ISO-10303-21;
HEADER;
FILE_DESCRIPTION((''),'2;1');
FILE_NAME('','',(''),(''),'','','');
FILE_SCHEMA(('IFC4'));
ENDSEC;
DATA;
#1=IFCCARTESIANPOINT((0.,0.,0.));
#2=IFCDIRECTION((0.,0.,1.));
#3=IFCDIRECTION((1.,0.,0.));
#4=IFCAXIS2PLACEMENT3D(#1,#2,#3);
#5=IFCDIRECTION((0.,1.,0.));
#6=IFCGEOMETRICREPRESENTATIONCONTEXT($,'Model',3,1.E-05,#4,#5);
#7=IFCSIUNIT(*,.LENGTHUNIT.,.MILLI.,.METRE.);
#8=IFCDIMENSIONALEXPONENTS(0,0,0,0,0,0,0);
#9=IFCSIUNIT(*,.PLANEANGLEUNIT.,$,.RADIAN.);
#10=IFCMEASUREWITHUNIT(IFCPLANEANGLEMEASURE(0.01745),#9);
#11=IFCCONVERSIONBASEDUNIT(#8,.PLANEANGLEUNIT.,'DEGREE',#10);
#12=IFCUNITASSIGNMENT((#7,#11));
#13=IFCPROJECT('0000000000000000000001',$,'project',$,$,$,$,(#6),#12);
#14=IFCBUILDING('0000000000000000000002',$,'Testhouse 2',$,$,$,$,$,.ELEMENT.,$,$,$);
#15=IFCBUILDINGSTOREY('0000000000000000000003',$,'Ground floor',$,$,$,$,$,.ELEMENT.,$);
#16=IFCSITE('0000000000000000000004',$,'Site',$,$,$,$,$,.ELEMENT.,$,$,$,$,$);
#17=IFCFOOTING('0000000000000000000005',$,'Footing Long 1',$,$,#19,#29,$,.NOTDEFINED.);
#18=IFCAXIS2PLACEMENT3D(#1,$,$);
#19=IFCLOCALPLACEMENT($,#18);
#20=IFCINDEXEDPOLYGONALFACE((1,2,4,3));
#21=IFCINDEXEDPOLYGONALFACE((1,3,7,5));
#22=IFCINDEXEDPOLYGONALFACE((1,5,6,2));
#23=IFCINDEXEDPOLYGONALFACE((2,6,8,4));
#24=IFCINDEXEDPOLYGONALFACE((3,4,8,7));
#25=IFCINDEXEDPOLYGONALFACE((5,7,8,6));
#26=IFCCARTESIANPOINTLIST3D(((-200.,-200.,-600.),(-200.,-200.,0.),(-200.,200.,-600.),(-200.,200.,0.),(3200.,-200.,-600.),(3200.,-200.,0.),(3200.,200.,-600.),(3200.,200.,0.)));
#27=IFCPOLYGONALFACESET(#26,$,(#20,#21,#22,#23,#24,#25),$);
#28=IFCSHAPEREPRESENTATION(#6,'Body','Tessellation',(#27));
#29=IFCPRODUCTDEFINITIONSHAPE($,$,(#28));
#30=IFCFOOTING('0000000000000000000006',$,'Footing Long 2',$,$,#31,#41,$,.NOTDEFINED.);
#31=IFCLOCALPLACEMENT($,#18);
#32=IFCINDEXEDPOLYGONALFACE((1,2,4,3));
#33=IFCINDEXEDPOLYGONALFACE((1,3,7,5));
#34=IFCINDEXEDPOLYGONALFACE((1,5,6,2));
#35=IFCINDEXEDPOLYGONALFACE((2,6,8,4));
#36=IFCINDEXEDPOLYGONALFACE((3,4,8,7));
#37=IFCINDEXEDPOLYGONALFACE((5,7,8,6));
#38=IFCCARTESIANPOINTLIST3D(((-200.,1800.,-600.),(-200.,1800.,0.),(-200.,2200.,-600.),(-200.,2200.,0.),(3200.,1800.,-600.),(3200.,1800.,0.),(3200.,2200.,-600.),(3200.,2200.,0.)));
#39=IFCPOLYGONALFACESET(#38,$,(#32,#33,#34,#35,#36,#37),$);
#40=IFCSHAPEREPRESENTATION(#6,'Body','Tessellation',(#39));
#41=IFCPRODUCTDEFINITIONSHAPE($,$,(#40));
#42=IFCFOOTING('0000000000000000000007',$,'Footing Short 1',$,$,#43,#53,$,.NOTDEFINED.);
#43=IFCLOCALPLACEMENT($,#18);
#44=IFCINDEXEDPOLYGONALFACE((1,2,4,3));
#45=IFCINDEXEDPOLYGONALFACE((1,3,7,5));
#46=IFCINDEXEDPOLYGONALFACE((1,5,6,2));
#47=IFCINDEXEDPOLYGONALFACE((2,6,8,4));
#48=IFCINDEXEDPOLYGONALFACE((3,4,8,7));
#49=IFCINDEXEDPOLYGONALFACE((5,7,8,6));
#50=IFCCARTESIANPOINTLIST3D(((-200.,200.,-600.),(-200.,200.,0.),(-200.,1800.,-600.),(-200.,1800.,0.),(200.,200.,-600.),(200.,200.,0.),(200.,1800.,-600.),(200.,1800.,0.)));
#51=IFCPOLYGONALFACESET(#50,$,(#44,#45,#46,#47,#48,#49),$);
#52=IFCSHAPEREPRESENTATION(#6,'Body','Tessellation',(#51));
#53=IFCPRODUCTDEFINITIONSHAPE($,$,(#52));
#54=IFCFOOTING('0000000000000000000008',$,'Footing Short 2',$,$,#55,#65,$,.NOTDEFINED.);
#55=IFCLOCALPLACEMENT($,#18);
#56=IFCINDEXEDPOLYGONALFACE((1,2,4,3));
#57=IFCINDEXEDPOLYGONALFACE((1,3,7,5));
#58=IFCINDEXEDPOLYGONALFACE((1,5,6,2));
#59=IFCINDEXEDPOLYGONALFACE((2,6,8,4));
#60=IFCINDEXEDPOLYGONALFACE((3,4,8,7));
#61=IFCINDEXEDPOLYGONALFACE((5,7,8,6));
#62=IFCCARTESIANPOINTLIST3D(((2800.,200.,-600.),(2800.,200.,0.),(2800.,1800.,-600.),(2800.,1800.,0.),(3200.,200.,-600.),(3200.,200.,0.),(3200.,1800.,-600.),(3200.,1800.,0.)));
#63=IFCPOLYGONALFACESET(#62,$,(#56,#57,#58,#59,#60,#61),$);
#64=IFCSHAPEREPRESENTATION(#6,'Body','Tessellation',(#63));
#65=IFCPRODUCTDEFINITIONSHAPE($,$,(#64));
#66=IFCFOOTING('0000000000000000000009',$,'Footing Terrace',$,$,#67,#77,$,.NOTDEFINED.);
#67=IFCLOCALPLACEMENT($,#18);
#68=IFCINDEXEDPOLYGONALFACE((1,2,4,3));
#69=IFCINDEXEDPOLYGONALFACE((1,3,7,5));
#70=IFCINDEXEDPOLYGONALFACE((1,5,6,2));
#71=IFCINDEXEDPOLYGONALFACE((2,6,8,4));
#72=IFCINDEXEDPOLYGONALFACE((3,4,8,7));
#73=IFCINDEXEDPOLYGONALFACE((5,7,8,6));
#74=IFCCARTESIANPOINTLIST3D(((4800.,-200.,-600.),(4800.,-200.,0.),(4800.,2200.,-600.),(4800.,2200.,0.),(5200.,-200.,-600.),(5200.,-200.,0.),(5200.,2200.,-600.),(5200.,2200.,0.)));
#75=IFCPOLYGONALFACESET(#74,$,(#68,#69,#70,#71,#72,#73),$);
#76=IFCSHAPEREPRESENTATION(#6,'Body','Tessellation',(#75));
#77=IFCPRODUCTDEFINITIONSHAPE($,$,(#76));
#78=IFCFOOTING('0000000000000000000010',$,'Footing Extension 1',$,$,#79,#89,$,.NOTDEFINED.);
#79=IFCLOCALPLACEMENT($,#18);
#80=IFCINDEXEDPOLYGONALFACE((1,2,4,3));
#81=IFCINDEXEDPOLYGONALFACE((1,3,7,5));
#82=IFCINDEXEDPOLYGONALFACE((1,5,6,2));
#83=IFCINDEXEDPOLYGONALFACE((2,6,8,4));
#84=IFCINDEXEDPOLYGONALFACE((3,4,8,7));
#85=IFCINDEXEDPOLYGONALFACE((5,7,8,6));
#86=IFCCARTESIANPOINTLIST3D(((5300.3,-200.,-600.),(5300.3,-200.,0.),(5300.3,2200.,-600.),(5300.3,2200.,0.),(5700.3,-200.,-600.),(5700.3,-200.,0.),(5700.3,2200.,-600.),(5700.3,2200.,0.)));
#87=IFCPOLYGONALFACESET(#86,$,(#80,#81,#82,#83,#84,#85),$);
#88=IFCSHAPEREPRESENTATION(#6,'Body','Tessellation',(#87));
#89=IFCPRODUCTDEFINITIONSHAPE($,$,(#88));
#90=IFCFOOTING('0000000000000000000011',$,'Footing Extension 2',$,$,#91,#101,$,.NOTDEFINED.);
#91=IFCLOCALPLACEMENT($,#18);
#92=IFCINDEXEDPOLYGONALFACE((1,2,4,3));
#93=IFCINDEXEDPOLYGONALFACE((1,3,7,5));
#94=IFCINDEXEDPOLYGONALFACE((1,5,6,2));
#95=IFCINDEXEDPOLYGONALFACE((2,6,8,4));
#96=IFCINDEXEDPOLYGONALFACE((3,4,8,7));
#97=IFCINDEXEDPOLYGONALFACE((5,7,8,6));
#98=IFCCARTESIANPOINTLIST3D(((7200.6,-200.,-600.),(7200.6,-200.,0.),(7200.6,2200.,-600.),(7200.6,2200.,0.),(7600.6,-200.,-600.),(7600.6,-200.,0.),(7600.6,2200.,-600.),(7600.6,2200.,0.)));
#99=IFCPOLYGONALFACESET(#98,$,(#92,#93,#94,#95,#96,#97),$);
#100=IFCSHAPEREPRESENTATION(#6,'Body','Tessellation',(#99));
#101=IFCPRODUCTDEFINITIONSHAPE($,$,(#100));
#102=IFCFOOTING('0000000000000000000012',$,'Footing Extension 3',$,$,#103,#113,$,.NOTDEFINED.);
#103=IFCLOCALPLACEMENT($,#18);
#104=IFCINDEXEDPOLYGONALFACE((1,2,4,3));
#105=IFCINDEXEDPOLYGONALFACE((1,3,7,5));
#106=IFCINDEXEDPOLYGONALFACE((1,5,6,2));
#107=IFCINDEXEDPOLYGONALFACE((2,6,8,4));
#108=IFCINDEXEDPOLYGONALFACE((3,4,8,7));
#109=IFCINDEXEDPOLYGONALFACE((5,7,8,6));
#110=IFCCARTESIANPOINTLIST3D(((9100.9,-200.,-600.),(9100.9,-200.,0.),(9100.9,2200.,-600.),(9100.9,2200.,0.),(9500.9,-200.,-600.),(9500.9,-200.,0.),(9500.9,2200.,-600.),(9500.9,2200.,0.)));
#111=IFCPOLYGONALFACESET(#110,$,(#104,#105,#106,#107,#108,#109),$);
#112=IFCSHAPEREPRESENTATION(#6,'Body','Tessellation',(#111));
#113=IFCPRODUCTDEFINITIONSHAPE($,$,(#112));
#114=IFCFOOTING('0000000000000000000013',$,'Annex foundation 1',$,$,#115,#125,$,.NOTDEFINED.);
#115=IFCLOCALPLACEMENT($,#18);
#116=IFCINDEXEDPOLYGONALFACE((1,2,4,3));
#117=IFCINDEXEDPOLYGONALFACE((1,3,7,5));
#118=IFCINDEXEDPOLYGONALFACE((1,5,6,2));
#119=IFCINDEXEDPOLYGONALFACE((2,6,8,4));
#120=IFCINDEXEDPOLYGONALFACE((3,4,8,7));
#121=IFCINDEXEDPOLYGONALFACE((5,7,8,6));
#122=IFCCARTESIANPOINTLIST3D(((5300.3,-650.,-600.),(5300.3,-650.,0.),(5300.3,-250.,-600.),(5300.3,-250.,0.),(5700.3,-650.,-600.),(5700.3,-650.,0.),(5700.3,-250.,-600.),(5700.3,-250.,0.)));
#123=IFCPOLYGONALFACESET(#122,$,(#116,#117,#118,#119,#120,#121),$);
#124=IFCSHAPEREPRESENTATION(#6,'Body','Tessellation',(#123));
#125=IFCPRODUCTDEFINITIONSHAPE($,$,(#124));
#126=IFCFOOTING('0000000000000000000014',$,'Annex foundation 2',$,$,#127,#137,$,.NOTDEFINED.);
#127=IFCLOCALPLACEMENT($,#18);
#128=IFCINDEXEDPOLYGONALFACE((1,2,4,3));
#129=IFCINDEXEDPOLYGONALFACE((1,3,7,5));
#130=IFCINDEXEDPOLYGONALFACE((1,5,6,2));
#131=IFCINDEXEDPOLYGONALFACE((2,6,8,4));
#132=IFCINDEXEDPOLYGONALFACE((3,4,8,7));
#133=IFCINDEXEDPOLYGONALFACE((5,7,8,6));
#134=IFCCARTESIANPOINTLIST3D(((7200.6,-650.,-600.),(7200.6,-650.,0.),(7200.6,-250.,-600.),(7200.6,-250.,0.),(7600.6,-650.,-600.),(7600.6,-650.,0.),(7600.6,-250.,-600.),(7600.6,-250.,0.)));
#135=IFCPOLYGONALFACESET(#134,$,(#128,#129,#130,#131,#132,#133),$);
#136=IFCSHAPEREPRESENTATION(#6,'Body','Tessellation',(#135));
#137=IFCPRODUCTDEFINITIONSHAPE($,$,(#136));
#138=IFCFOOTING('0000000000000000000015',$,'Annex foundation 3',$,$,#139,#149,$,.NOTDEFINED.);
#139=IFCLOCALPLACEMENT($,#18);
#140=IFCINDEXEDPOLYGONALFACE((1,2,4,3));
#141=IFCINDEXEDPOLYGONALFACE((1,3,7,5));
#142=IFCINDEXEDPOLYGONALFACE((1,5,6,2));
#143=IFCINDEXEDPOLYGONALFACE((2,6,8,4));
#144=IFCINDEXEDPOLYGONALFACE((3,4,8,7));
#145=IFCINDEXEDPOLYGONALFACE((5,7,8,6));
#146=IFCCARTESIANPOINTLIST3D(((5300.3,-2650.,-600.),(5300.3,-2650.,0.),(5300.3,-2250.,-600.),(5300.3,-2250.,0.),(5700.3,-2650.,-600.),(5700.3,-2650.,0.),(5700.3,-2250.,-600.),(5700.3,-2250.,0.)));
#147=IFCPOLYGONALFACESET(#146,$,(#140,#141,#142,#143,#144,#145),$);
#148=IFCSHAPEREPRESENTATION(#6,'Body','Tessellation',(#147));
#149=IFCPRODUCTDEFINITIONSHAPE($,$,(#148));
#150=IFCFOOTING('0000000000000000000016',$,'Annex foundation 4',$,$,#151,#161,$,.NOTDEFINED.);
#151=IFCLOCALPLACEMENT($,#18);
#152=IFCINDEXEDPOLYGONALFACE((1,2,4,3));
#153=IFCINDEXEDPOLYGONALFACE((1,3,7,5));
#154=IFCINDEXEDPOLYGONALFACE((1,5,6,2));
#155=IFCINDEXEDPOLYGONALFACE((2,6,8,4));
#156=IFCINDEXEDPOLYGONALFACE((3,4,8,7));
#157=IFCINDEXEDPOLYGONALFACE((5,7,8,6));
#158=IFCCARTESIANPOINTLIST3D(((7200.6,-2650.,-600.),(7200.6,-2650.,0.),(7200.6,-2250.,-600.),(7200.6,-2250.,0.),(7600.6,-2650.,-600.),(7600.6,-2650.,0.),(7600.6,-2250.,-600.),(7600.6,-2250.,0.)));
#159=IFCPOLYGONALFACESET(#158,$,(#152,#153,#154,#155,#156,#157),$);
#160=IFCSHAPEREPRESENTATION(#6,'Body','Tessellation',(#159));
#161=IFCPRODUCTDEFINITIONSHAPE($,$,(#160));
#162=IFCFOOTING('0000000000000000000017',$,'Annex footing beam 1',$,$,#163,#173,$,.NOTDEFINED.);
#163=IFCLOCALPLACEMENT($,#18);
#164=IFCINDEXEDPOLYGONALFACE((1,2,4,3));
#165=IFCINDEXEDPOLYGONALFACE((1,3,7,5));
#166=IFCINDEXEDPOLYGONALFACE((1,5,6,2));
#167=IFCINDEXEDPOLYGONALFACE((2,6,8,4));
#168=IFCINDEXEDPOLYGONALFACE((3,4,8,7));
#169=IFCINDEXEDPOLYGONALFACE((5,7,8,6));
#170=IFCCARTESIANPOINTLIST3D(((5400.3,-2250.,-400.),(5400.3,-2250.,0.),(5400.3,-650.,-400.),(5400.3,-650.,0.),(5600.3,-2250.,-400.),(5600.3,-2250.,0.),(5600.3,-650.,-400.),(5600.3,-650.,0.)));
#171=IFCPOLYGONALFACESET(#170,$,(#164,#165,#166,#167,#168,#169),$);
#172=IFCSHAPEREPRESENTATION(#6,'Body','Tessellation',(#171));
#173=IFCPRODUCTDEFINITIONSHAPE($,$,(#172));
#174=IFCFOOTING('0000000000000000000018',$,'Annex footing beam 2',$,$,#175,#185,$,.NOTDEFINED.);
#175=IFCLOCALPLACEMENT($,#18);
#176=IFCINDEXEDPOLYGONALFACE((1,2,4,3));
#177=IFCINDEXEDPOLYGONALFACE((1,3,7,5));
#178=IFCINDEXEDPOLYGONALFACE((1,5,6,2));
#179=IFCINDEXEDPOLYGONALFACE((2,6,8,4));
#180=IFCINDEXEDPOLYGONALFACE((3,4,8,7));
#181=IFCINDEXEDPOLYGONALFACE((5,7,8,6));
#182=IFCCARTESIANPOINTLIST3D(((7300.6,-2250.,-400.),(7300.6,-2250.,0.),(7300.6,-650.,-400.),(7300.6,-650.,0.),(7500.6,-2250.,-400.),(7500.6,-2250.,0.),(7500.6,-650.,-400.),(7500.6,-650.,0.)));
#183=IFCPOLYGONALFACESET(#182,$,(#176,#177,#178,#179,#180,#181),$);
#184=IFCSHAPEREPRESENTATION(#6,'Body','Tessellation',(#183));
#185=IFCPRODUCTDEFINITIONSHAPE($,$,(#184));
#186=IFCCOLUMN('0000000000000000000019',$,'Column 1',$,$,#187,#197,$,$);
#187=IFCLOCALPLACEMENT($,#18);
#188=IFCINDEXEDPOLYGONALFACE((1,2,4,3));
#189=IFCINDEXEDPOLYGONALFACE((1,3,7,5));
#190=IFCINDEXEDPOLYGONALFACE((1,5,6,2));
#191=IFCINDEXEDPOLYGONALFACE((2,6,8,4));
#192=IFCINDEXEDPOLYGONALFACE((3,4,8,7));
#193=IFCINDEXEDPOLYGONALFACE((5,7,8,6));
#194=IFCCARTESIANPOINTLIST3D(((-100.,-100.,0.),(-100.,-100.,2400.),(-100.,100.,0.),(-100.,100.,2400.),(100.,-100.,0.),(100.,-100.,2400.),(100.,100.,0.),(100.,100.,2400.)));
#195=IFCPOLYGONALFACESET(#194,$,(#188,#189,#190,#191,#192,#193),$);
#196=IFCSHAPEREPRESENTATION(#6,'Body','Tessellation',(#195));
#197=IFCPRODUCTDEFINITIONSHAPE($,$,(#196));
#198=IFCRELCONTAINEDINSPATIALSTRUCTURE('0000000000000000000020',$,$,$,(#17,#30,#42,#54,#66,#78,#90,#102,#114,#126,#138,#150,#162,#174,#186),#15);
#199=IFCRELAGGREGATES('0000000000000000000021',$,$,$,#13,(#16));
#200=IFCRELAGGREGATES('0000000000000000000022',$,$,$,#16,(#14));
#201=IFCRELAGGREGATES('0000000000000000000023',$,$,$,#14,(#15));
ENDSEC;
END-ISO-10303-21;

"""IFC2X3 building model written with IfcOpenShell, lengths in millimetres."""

from ifc_helpers import new_model, entity, si_unit, converted_unit, direction, frame, origin_with_axes, place, context, project, spatial, polyline, outline, extrude, element, save


model = new_model("IFC2X3")

# Units and contexts
model_context = context("Model", 3, precision=1e-05, world=origin_with_axes(), true_north=direction((0.0, 1.0, 0.0)))
ifc_project = project(units=[si_unit("LENGTHUNIT", "METRE", prefix="MILLI"), converted_unit("PLANEANGLEUNIT", "DEGREE", entity("IfcPlaneAngleMeasure", 0.01745), si_unit("PLANEANGLEUNIT", "RADIAN"), dimensions=[0, 0, 0, 0, 0, 0, 0])], contexts=[model_context])

# Site, building, storey
site = spatial("IfcSite", under=ifc_project, Name="Site", CompositionType="ELEMENT")
building = spatial("IfcBuilding", under=site, Name="Testhouse 2", CompositionType="ELEMENT")
storey = spatial("IfcBuildingStorey", under=building, Name="Ground floor", CompositionType="ELEMENT")

# Footings
footing_1_placement = place(None, origin_with_axes())
element("IfcFooting", 1, at=footing_1_placement, inside=storey, Name="Footing Long 1", PredefinedType="NOTDEFINED", context=model_context, shape_type="SweptSolid", body=[
    extrude(outline(polyline([(-300.0, -200.0), (300.0, -200.0), (300.0, 200.0), (-300.0, 200.0), (-300.0, -200.0)])), frame((-200.0, 0.0, -300.0), z_axis=(1.0, 0.0, 0.0), x_axis=(0.0, 0.0, -1.0)), (0.0, 0.0, 1.0), 3400.0),
])
footing_2_placement = place(None, origin_with_axes())
element("IfcFooting", 2, at=footing_2_placement, inside=storey, Name="Footing Long 2", PredefinedType="NOTDEFINED", context=model_context, shape_type="SweptSolid", body=[
    extrude(outline(polyline([(-300.0, -200.0), (300.0, -200.0), (300.0, 200.0), (-300.0, 200.0), (-300.0, -200.0)])), frame((-200.0, 2000.0, -300.0), z_axis=(1.0, 0.0, 0.0), x_axis=(0.0, 0.0, -1.0)), (0.0, 0.0, 1.0), 3400.0),
])
footing_3_placement = place(None, origin_with_axes())
element("IfcFooting", 3, at=footing_3_placement, inside=storey, Name="Footing Short 1", PredefinedType="NOTDEFINED", context=model_context, shape_type="SweptSolid", body=[
    extrude(outline(polyline([(-300.0, -200.0), (300.0, -200.0), (300.0, 200.0), (-300.0, 200.0), (-300.0, -200.0)])), frame((0.0, 200.0, -300.0), z_axis=(0.0, 1.0, 0.0), x_axis=(0.0, 0.0, -1.0)), (0.0, 0.0, 1.0), 1600.0),
])
footing_4_placement = place(None, origin_with_axes())
element("IfcFooting", 4, at=footing_4_placement, inside=storey, Name="Footing Short 2", PredefinedType="NOTDEFINED", context=model_context, shape_type="SweptSolid", body=[
    extrude(outline(polyline([(-300.0, -200.0), (300.0, -200.0), (300.0, 200.0), (-300.0, 200.0), (-300.0, -200.0)])), frame((3000.0, 200.0, -300.0), z_axis=(0.0, 1.0, 0.0), x_axis=(0.0, 0.0, -1.0)), (0.0, 0.0, 1.0), 1600.0),
])
footing_5_placement = place(None, origin_with_axes())
element("IfcFooting", 5, at=footing_5_placement, inside=storey, Name="Footing Terrace", PredefinedType="NOTDEFINED", context=model_context, shape_type="SweptSolid", body=[
    extrude(outline(polyline([(-300.0, -200.0), (300.0, -200.0), (300.0, 200.0), (-300.0, 200.0), (-300.0, -200.0)])), frame((5000.0, -200.0, -300.0), z_axis=(0.0, 1.0, 0.0), x_axis=(0.0, 0.0, -1.0)), (0.0, 0.0, 1.0), 2400.0),
])
footing_6_placement = place(None, origin_with_axes())
element("IfcFooting", 6, at=footing_6_placement, inside=storey, Name="Footing Extension 1", PredefinedType="NOTDEFINED", context=model_context, shape_type="SweptSolid", body=[
    extrude(outline(polyline([(-300.0, -200.0), (300.0, -200.0), (300.0, 200.0), (-300.0, 200.0), (-300.0, -200.0)])), frame((5500.3, -200.0, -300.0), z_axis=(0.0, 1.0, 0.0), x_axis=(0.0, 0.0, -1.0)), (0.0, 0.0, 1.0), 2400.0),
])
footing_7_placement = place(None, origin_with_axes())
element("IfcFooting", 7, at=footing_7_placement, inside=storey, Name="Footing Extension 2", PredefinedType="NOTDEFINED", context=model_context, shape_type="SweptSolid", body=[
    extrude(outline(polyline([(-300.0, -200.0), (300.0, -200.0), (300.0, 200.0), (-300.0, 200.0), (-300.0, -200.0)])), frame((7400.6, -200.0, -300.0), z_axis=(0.0, 1.0, 0.0), x_axis=(0.0, 0.0, -1.0)), (0.0, 0.0, 1.0), 2400.0),
])
footing_8_placement = place(None, origin_with_axes())
element("IfcFooting", 8, at=footing_8_placement, inside=storey, Name="Footing Extension 3", PredefinedType="NOTDEFINED", context=model_context, shape_type="SweptSolid", body=[
    extrude(outline(polyline([(-300.0, -200.0), (300.0, -200.0), (300.0, 200.0), (-300.0, 200.0), (-300.0, -200.0)])), frame((9300.9, -200.0, -300.0), z_axis=(0.0, 1.0, 0.0), x_axis=(0.0, 0.0, -1.0)), (0.0, 0.0, 1.0), 2400.0),
])
footing_9_placement = place(None, origin_with_axes())
element("IfcFooting", 9, at=footing_9_placement, inside=storey, Name="Annex foundation 1", PredefinedType="NOTDEFINED", context=model_context, shape_type="SweptSolid", body=[
    extrude(outline(polyline([(-200.0, -200.0), (200.0, -200.0), (200.0, 200.0), (-200.0, 200.0), (-200.0, -200.0)])), frame((5500.3, -450.0, -600.0), z_axis=(0.0, 0.0, 1.0), x_axis=(1.0, 0.0, 0.0)), (0.0, 0.0, 1.0), 600.0),
])
footing_10_placement = place(None, origin_with_axes())
element("IfcFooting", 10, at=footing_10_placement, inside=storey, Name="Annex foundation 2", PredefinedType="NOTDEFINED", context=model_context, shape_type="SweptSolid", body=[
    extrude(outline(polyline([(-200.0, -200.0), (200.0, -200.0), (200.0, 200.0), (-200.0, 200.0), (-200.0, -200.0)])), frame((7400.6, -450.0, -600.0), z_axis=(0.0, 0.0, 1.0), x_axis=(1.0, 0.0, 0.0)), (0.0, 0.0, 1.0), 600.0),
])
footing_11_placement = place(None, origin_with_axes())
element("IfcFooting", 11, at=footing_11_placement, inside=storey, Name="Annex foundation 3", PredefinedType="NOTDEFINED", context=model_context, shape_type="SweptSolid", body=[
    extrude(outline(polyline([(-200.0, -200.0), (200.0, -200.0), (200.0, 200.0), (-200.0, 200.0), (-200.0, -200.0)])), frame((5500.3, -2450.0, -600.0), z_axis=(0.0, 0.0, 1.0), x_axis=(1.0, 0.0, 0.0)), (0.0, 0.0, 1.0), 600.0),
])
footing_12_placement = place(None, origin_with_axes())
element("IfcFooting", 12, at=footing_12_placement, inside=storey, Name="Annex foundation 4", PredefinedType="NOTDEFINED", context=model_context, shape_type="SweptSolid", body=[
    extrude(outline(polyline([(-200.0, -200.0), (200.0, -200.0), (200.0, 200.0), (-200.0, 200.0), (-200.0, -200.0)])), frame((7400.6, -2450.0, -600.0), z_axis=(0.0, 0.0, 1.0), x_axis=(1.0, 0.0, 0.0)), (0.0, 0.0, 1.0), 600.0),
])
footing_13_placement = place(None, origin_with_axes())
element("IfcFooting", 13, at=footing_13_placement, inside=storey, Name="Annex footing beam 1", PredefinedType="NOTDEFINED", context=model_context, shape_type="SweptSolid", body=[
    extrude(outline(polyline([(-200.0, -100.0), (200.0, -100.0), (200.0, 100.0), (-200.0, 100.0), (-200.0, -100.0)])), frame((5500.3, -2250.0, -200.0), z_axis=(0.0, 1.0, 0.0), x_axis=(0.0, 0.0, -1.0)), (0.0, 0.0, 1.0), 1600.0),
])
footing_14_placement = place(None, origin_with_axes())
element("IfcFooting", 14, at=footing_14_placement, inside=storey, Name="Annex footing beam 2", PredefinedType="NOTDEFINED", context=model_context, shape_type="SweptSolid", body=[
    extrude(outline(polyline([(-200.0, -100.0), (200.0, -100.0), (200.0, 100.0), (-200.0, 100.0), (-200.0, -100.0)])), frame((7400.6, -2250.0, -200.0), z_axis=(0.0, 1.0, 0.0), x_axis=(0.0, 0.0, -1.0)), (0.0, 0.0, 1.0), 1600.0),
])

# Column
column_1_placement = place(None, origin_with_axes())
element("IfcColumn", 15, at=column_1_placement, inside=storey, Name="Column 1", context=model_context, shape_type="SweptSolid", body=[
    extrude(outline(polyline([(-100.0, -100.0), (100.0, -100.0), (100.0, 100.0), (-100.0, 100.0), (-100.0, -100.0)])), origin_with_axes(), (0.0, 0.0, 1.0), 2400.0),
])

save(model, "model.ifc")
